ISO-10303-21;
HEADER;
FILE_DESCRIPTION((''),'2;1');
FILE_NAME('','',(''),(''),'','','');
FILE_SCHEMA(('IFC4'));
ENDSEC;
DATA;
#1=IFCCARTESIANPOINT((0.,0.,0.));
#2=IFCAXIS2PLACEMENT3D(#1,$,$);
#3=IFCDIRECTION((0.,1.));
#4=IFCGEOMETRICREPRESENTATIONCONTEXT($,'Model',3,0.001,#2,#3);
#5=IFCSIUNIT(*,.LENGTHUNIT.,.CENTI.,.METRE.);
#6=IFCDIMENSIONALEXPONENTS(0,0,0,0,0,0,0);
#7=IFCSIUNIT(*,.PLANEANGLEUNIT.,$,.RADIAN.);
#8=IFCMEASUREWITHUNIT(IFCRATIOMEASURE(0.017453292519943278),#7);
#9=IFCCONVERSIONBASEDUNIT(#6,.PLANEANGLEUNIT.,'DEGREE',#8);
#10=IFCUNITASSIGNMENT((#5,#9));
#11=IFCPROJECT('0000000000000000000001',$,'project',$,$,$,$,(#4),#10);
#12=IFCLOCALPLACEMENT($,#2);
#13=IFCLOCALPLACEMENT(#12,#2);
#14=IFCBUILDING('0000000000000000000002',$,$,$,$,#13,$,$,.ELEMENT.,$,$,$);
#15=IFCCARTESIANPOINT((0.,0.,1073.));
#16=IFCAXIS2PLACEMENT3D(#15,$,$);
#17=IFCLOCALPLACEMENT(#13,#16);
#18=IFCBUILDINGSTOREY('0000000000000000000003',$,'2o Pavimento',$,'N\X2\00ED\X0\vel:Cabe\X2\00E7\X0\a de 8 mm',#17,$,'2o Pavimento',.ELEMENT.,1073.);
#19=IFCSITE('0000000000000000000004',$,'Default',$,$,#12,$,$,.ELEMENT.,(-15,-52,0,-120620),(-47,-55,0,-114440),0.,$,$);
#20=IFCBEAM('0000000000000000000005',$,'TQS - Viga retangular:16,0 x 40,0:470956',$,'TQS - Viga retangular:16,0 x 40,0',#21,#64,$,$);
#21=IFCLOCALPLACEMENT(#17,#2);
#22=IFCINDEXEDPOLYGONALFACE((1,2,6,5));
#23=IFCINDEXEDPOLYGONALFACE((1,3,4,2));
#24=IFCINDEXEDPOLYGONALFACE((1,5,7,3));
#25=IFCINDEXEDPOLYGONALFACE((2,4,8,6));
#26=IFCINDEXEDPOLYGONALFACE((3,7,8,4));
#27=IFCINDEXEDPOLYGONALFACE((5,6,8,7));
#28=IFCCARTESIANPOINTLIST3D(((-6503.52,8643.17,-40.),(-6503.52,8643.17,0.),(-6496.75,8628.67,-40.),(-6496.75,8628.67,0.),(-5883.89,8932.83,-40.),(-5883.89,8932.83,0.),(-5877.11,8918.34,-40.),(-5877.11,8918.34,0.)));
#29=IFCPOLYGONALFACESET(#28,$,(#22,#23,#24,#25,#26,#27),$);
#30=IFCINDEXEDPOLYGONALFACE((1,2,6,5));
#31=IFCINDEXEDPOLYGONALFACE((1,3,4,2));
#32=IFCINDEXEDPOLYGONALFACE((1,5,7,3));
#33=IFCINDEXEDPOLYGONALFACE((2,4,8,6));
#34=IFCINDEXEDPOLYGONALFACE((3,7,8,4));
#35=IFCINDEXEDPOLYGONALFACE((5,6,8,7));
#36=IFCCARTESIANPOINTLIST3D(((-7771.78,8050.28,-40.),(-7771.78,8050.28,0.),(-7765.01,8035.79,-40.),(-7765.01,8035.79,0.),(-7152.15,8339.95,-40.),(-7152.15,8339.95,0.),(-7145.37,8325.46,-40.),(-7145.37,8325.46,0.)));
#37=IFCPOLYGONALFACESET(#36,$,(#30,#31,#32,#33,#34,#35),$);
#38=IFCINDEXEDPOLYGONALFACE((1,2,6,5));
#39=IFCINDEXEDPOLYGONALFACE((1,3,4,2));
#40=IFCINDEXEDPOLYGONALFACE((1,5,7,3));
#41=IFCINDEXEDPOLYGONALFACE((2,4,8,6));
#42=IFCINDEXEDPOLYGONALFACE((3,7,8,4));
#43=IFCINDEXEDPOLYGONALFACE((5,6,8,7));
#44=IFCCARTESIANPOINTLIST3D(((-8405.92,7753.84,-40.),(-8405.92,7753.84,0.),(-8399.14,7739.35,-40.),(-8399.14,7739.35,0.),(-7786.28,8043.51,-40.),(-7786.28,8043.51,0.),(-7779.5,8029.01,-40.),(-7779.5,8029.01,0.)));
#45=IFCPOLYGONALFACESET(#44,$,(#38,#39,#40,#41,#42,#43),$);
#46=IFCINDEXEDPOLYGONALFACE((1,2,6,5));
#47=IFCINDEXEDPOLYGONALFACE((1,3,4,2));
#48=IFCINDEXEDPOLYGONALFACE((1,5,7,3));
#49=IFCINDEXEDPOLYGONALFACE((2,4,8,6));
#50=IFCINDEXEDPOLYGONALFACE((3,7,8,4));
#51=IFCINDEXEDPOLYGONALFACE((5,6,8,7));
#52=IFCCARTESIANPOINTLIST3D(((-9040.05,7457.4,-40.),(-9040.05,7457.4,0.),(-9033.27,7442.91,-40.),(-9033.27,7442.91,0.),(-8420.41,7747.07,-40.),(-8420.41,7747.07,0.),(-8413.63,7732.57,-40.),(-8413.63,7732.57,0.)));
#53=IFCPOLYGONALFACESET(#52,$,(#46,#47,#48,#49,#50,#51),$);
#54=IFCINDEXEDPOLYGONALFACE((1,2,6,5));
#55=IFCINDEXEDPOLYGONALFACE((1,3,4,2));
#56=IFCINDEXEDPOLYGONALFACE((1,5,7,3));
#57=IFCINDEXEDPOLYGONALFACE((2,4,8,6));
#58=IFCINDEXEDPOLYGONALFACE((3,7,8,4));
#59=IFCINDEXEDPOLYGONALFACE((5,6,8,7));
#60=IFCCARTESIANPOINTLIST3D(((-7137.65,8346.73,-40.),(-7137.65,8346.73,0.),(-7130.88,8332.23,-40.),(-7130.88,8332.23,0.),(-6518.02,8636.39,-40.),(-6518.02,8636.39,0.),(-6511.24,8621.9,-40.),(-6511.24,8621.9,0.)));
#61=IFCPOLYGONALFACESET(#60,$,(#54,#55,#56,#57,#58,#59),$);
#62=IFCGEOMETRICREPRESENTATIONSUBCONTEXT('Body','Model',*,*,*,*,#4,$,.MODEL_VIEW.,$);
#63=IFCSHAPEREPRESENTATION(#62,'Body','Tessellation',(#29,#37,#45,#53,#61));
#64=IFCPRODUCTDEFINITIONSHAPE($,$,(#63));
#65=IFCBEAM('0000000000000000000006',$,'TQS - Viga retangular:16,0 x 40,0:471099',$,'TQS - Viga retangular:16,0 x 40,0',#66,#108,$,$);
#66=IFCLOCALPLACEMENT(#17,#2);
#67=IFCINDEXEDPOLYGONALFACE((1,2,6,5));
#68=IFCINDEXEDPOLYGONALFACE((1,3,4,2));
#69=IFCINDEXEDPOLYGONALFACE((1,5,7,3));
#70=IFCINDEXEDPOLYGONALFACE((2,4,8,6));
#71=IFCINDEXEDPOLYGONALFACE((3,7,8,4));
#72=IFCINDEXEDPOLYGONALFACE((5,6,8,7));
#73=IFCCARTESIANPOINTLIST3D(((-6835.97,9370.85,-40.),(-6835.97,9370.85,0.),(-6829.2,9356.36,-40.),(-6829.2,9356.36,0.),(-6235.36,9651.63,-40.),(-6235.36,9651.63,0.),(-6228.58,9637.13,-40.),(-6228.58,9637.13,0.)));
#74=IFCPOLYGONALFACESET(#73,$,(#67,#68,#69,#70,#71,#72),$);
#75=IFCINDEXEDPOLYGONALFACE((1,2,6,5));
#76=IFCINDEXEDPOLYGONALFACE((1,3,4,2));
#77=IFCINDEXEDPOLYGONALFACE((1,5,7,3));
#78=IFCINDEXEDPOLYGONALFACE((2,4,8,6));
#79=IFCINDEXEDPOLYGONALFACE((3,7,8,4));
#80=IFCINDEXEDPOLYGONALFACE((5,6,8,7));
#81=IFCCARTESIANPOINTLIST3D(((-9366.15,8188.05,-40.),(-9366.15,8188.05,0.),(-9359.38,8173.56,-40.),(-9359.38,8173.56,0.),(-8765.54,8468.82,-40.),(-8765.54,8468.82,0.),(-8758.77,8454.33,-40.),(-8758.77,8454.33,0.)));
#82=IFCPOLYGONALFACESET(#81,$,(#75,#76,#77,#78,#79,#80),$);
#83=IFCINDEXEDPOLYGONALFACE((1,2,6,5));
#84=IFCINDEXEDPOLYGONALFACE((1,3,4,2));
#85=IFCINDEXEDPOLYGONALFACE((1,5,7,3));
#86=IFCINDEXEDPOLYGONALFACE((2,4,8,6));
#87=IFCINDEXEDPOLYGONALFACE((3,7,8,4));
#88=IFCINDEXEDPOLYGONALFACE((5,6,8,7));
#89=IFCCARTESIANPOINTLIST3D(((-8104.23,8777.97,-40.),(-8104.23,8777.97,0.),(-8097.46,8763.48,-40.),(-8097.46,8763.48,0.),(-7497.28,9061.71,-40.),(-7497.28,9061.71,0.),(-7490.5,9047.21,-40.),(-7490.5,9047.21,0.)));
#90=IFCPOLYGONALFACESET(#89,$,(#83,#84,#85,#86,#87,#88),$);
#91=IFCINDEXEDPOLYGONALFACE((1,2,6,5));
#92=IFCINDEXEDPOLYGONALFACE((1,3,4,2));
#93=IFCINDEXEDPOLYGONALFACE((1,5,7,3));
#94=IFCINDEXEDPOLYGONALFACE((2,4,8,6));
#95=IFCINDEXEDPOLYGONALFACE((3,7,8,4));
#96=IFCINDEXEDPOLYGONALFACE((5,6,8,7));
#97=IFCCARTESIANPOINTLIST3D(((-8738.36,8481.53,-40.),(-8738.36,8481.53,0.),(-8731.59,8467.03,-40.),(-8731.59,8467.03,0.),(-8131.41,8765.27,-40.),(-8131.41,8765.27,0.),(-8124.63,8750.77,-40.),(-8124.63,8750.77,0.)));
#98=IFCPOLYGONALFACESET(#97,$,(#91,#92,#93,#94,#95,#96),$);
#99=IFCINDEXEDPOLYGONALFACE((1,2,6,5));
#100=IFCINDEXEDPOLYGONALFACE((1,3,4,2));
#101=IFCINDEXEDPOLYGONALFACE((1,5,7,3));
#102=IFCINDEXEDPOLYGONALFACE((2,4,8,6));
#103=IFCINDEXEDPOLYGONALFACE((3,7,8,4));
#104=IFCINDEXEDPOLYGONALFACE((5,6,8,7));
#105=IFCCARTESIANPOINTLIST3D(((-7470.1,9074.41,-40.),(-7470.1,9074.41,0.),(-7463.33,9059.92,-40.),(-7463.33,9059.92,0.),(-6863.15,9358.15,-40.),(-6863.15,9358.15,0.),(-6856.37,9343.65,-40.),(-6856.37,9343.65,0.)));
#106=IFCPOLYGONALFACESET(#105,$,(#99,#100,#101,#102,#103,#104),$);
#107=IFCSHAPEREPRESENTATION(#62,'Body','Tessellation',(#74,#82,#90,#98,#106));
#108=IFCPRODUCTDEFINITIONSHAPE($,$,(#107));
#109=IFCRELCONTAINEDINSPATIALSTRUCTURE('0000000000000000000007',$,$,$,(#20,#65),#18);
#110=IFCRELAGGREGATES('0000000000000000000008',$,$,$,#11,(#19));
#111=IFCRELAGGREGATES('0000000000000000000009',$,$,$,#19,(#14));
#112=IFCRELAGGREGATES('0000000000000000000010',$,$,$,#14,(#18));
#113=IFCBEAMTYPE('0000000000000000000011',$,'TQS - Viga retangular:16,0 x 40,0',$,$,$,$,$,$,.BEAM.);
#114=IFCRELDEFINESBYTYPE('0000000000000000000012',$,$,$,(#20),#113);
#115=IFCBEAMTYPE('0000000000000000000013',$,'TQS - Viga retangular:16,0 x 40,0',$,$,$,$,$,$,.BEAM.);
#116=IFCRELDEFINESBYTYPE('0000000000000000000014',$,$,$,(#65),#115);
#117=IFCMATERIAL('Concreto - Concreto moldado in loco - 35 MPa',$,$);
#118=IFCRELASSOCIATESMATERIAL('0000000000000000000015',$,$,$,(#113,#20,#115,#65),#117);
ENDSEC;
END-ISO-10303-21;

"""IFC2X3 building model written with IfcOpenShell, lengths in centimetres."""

from ifc_helpers import new_model, entity, si_unit, converted_unit, direction, frame, frame_2d, origin, origin_2d_with_axis, place, context, subcontext, project, spatial, rectangle, extrude, source, transform, mapped, material, type_object, type_shapes, element, save


model = new_model("IFC2X3")

# Units and contexts
model_context = context("Model", 3, precision=0.001, world=origin(), true_north=direction((0.0, 1.0)))
body_context = subcontext(model_context, "Body", "Model", "MODEL_VIEW")
ifc_project = project(units=[si_unit("LENGTHUNIT", "METRE", prefix="CENTI"), converted_unit("PLANEANGLEUNIT", "DEGREE", entity("IfcRatioMeasure", 0.017453292519943278), si_unit("PLANEANGLEUNIT", "RADIAN"), dimensions=[0, 0, 0, 0, 0, 0, 0])], contexts=[model_context])

# Site, building, storey
site_placement = place(None, origin())
site = spatial("IfcSite", under=ifc_project, at=site_placement, Name="Default", CompositionType="ELEMENT", RefLatitude=(-15, -52, 0, -120620), RefLongitude=(-47, -55, 0, -114440), RefElevation=0.0)
building_placement = place(site_placement, origin())
building = spatial("IfcBuilding", under=site, at=building_placement, CompositionType="ELEMENT")
storey_placement = place(building_placement, frame((0.0, 0.0, 1073.0)))
storey = spatial("IfcBuildingStorey", under=building, at=storey_placement, Name="2o Pavimento", ObjectType="Nível:Cabeça de 8 mm", LongName="2o Pavimento", CompositionType="ELEMENT", Elevation=1073.0)

# Shared definitions
ifc_material = material(Name="Concreto - Concreto moldado in loco - 35 MPa")

# Beams
beam_type_1 = type_object("IfcBeamType", Name="TQS - Viga retangular:16,0 x 40,0", PredefinedType="BEAM", material=ifc_material)
shared_shape_1 = source(origin(), body_context, "Body", "SweptSolid", [
    extrude(rectangle(XDim=40.0, YDim=16.0, at=frame_2d((0.0, 0.0), x_axis=(1.0, 0.0))), frame((-6500.13, 8635.92, 1053.0), z_axis=(0.905902, 0.423488, 0.0), x_axis=(0.0, 0.0, 1.0)), (0.0, 0.0, 1.0), 684.0),
    extrude(rectangle(XDim=40.0, YDim=16.0, at=origin_2d_with_axis()), frame((-7768.4, 8043.04, 1053.0), z_axis=(0.905902, 0.423488, 0.0), x_axis=(0.0, 0.0, 1.0)), (0.0, 0.0, 1.0), 684.0),
    extrude(rectangle(XDim=40.0, YDim=16.0, at=origin_2d_with_axis()), frame((-8402.53, 7746.6, 1053.0), z_axis=(0.905902, 0.423488, 0.0), x_axis=(0.0, 0.0, 1.0)), (0.0, 0.0, 1.0), 684.0),
    extrude(rectangle(XDim=40.0, YDim=16.0, at=frame_2d((0.0, 0.0), x_axis=(1.0, 0.0))), frame((-9036.66, 7450.15, 1053.0), z_axis=(0.905902, 0.423488, 0.0), x_axis=(0.0, 0.0, 1.0)), (0.0, 0.0, 1.0), 684.0),
    extrude(rectangle(XDim=40.0, YDim=16.0, at=frame_2d((0.0, 0.0), x_axis=(1.0, 0.0))), frame((-7134.27, 8339.48, 1053.0), z_axis=(0.905902, 0.423488, 0.0), x_axis=(0.0, 0.0, 1.0)), (0.0, 0.0, 1.0), 684.0),
])
type_shapes(beam_type_1, [shared_shape_1])
beam_1_placement = place(storey_placement, frame((0.0, 0.0, -1073.0)))
element("IfcBeam", 1, at=beam_1_placement, inside=storey, type_object=beam_type_1, material=ifc_material, Name="TQS - Viga retangular:16,0 x 40,0:470956", ObjectType="TQS - Viga retangular:16,0 x 40,0", context=body_context, shape_type="MappedRepresentation", body=[
    mapped(shared_shape_1, transform((0.0, 0.0, 0.0), scale=1.0)),
])
beam_type_2 = type_object("IfcBeamType", Name="TQS - Viga retangular:16,0 x 40,0", PredefinedType="BEAM", material=ifc_material)
shared_shape_2 = source(origin(), body_context, "Body", "SweptSolid", [
    extrude(rectangle(XDim=40.0, YDim=16.0, at=origin_2d_with_axis()), frame((-6832.58, 9363.61, 1053.0), z_axis=(0.905902, 0.423488, 0.0), x_axis=(0.0, 0.0, 1.0)), (0.0, 0.0, 1.0), 663.0),
    extrude(rectangle(XDim=40.0, YDim=16.0, at=origin_2d_with_axis()), frame((-9362.77, 8180.81, 1053.0), z_axis=(0.905902, 0.423488, 0.0), x_axis=(0.0, 0.0, 1.0)), (0.0, 0.0, 1.0), 663.0),
    extrude(rectangle(XDim=40.0, YDim=16.0, at=origin_2d_with_axis()), frame((-8100.85, 8770.72, 1053.0), z_axis=(0.905902, 0.423488, 0.0), x_axis=(0.0, 0.0, 1.0)), (0.0, 0.0, 1.0), 670.0),
    extrude(rectangle(XDim=40.0, YDim=16.0, at=origin_2d_with_axis()), frame((-8734.98, 8474.28, 1053.0), z_axis=(0.905902, 0.423488, 0.0), x_axis=(0.0, 0.0, 1.0)), (0.0, 0.0, 1.0), 670.0),
    extrude(rectangle(XDim=40.0, YDim=16.0, at=frame_2d((0.0, 0.0), x_axis=(1.0, 0.0))), frame((-7466.71, 9067.16, 1053.0), z_axis=(0.905902, 0.423488, 0.0), x_axis=(0.0, 0.0, 1.0)), (0.0, 0.0, 1.0), 670.0),
])
type_shapes(beam_type_2, [shared_shape_2])
beam_2_placement = place(storey_placement, frame((0.0, 0.0, -1073.0)))
element("IfcBeam", 2, at=beam_2_placement, inside=storey, type_object=beam_type_2, material=ifc_material, Name="TQS - Viga retangular:16,0 x 40,0:471099", ObjectType="TQS - Viga retangular:16,0 x 40,0", context=body_context, shape_type="MappedRepresentation", body=[
    mapped(shared_shape_2, transform((0.0, 0.0, 0.0), scale=1.0)),
])

save(model, "model.ifc")
